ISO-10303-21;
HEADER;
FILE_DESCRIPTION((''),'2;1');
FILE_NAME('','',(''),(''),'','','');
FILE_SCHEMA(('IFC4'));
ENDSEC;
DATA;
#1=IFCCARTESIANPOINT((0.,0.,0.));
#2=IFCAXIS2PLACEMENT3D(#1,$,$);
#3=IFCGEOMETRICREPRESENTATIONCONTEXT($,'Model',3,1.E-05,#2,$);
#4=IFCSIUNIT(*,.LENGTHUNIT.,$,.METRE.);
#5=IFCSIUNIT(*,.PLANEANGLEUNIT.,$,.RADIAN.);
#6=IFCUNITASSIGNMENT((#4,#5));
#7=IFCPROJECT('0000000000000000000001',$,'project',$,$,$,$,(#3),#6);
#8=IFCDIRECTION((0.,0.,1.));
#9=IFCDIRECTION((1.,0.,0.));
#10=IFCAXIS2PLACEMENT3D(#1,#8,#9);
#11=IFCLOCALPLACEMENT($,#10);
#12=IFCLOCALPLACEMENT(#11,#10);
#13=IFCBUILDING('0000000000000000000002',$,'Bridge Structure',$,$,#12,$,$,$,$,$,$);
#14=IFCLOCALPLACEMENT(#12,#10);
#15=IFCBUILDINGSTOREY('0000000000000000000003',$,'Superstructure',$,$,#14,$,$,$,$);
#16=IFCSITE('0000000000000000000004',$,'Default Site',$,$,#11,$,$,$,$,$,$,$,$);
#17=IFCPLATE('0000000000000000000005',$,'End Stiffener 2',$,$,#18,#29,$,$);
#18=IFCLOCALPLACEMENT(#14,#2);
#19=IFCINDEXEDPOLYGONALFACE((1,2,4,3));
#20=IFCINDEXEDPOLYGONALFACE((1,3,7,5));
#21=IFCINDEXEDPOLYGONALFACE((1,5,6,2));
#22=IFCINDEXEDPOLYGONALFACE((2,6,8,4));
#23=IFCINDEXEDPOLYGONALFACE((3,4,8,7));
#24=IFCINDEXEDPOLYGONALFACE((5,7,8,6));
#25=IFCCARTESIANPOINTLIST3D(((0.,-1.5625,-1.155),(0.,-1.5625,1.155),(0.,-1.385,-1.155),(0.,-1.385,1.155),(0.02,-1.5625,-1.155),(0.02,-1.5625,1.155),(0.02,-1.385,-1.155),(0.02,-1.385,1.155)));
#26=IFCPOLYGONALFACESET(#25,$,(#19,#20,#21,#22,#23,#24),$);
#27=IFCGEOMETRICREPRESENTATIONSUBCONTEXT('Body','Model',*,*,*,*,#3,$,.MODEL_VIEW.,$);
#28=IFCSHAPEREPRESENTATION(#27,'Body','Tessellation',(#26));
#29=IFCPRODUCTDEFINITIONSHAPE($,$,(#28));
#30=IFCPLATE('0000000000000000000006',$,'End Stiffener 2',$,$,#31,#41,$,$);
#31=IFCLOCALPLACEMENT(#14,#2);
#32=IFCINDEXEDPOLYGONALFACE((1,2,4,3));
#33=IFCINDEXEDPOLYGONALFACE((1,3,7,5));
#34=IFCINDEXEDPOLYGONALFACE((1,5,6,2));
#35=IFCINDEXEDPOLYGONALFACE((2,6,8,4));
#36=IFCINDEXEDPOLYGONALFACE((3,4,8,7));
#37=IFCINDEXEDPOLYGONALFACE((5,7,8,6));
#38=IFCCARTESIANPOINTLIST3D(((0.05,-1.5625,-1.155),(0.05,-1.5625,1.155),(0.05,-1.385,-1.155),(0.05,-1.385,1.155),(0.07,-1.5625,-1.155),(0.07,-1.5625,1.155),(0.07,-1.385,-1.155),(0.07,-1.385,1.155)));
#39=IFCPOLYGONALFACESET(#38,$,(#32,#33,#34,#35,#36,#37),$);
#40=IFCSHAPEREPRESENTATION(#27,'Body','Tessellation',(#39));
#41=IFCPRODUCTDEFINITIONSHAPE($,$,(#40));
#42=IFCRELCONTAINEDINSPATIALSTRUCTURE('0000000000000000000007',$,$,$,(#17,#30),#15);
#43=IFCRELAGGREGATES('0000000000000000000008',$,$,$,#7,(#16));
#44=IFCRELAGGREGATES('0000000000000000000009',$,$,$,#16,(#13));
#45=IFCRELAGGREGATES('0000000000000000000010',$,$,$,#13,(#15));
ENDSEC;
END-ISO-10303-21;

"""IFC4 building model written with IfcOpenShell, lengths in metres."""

from ifc_helpers import new_model, si_unit, frame, origin, origin_with_axes, origin_2d_with_axis, place, context, subcontext, project, spatial, rectangle, extrude, element, save


model = new_model("IFC4")

# Units and contexts
model_context = context("Model", 3, precision=1e-05, world=origin())
body_context = subcontext(model_context, "Body", "Model", "MODEL_VIEW")
ifc_project = project(units=[si_unit("LENGTHUNIT", "METRE"), si_unit("PLANEANGLEUNIT", "RADIAN")], contexts=[model_context])

# Site, building, storey
site_placement = place(None, origin_with_axes())
site = spatial("IfcSite", under=ifc_project, at=site_placement, Name="Default Site")
building_placement = place(site_placement, origin_with_axes())
building = spatial("IfcBuilding", under=site, at=building_placement, Name="Bridge Structure")
storey_placement = place(building_placement, origin_with_axes())
storey = spatial("IfcBuildingStorey", under=building, at=storey_placement, Name="Superstructure")

# Plates
for number, where, z_axis, x_axis, name in (
    (1, (0.01, -1.4738, -1.155), (0.0, 0.0, 1.0), (1.0, 0.0, 0.0), "End Stiffener 2"),
    (2, (0.06, -1.4738, -1.155), (0.0, 0.0, 1.0), (1.0, 0.0, 0.0), "End Stiffener 2"),
):
    element("IfcPlate", number, at=place(storey_placement, frame(where, z_axis=z_axis, x_axis=x_axis)), inside=storey, Name=name, context=body_context, shape_type="SweptSolid", body=[
        extrude(rectangle(XDim=0.02, YDim=0.1775, at=origin_2d_with_axis()), origin_with_axes(), (0.0, 0.0, 1.0), 2.31),
    ])

save(model, "model.ifc")
